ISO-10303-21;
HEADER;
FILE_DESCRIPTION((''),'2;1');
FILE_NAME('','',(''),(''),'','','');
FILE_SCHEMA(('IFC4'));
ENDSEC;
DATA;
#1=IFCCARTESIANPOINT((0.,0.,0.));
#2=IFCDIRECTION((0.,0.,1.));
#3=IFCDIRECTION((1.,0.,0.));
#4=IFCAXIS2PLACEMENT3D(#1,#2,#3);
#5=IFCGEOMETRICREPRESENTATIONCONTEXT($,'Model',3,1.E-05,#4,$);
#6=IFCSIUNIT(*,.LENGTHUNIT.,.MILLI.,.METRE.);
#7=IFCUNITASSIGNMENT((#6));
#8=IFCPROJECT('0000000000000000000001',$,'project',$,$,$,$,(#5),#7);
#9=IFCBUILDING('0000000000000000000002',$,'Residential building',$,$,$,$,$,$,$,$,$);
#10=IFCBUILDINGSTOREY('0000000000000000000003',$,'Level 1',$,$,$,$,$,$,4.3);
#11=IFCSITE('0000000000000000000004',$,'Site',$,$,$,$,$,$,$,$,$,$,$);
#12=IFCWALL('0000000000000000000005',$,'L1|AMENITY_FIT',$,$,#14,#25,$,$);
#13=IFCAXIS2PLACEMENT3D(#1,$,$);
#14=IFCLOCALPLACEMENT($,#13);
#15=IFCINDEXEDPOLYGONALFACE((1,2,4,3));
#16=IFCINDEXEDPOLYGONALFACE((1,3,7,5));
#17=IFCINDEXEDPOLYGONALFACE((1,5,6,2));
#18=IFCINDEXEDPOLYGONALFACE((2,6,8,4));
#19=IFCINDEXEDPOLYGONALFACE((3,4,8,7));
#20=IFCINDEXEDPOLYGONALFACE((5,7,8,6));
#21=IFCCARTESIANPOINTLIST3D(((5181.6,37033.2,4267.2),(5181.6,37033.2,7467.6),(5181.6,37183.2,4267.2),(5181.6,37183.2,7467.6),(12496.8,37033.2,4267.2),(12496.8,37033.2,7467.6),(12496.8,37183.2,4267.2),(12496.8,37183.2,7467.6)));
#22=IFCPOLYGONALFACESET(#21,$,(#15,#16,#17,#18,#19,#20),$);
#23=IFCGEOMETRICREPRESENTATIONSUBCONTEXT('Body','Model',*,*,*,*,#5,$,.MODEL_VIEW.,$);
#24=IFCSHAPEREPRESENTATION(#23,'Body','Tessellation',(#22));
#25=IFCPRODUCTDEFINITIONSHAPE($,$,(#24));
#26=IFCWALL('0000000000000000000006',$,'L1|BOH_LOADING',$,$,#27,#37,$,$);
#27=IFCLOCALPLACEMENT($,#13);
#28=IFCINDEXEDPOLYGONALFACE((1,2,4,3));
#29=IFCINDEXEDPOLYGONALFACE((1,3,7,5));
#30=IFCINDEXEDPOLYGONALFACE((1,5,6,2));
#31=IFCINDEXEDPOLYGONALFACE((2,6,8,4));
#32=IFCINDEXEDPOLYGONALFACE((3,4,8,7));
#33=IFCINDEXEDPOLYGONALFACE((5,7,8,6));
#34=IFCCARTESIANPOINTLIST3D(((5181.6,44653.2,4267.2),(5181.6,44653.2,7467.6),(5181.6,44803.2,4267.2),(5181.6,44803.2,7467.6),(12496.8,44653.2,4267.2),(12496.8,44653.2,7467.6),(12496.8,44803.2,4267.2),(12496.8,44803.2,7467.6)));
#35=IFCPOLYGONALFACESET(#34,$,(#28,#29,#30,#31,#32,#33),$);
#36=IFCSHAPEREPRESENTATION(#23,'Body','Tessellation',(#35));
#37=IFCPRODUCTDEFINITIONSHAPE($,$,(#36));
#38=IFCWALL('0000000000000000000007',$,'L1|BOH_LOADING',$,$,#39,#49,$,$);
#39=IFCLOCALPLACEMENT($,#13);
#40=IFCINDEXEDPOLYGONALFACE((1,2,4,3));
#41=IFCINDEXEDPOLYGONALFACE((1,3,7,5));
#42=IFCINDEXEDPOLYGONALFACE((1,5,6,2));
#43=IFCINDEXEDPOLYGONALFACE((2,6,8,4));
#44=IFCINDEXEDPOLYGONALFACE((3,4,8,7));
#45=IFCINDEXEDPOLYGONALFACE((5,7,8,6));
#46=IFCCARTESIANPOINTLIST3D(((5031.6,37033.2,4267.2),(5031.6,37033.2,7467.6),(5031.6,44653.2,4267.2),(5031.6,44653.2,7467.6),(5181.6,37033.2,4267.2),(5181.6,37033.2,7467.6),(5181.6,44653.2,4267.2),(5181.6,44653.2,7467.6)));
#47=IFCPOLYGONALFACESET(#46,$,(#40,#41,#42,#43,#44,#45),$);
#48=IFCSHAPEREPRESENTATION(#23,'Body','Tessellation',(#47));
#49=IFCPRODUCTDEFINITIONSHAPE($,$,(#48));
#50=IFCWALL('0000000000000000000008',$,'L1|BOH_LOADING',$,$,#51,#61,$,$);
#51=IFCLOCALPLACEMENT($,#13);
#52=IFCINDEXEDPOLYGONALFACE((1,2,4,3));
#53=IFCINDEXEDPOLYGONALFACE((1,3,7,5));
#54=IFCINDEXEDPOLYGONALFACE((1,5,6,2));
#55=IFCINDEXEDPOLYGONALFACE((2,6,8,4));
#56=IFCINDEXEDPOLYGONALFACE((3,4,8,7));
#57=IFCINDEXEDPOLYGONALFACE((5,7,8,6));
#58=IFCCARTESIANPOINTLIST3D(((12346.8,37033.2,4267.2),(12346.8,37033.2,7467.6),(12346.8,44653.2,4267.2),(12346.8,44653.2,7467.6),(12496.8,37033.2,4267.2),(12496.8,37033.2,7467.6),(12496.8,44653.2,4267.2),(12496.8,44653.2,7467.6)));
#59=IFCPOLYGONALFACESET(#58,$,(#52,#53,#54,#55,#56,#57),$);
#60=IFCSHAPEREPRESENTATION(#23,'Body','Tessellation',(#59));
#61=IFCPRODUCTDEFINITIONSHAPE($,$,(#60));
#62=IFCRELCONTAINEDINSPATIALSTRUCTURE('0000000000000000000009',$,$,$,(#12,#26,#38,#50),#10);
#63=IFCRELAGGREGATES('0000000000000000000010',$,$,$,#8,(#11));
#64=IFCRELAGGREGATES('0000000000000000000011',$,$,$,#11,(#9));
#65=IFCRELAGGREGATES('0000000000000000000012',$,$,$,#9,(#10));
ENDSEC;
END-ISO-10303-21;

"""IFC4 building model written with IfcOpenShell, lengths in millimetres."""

from ifc_helpers import new_model, si_unit, frame, origin_with_axes, place, context, subcontext, project, spatial, indexed_curve, outline, extrude, element, save


model = new_model("IFC4")

# Units and contexts
model_context = context("Model", 3, precision=1e-05, world=origin_with_axes())
body_context = subcontext(model_context, "Body", "Model", "MODEL_VIEW")
ifc_project = project(units=[si_unit("LENGTHUNIT", "METRE", prefix="MILLI")], contexts=[model_context])

# Site, building, storey
site = spatial("IfcSite", under=ifc_project, Name="Site")
building = spatial("IfcBuilding", under=site, Name="Residential building")
storey = spatial("IfcBuildingStorey", under=building, Name="Level 1", Elevation=4.3)

# Walls
for number, where, z_axis, x_axis, name in (
    (1, (5181.6, 37033.2, 4267.2), (0.0, 0.0, 1.0), (1.0, 0.0, 0.0), "L1|AMENITY_FIT"),
    (2, (5181.6, 44653.2, 4267.2), (0.0, 0.0, 1.0), (1.0, 0.0, 0.0), "L1|BOH_LOADING"),
):
    element("IfcWall", number, at=place(None, frame(where, z_axis=z_axis, x_axis=x_axis)), inside=storey, Name=name, context=body_context, shape_type="SweptSolid", body=[
        extrude(outline(indexed_curve([(0.0, 0.0), (0.0, 150.0), (7315.2, 150.0), (7315.2, 0.0), (0.0, 0.0)], self_intersect=False)), origin_with_axes(), (0.0, 0.0, 1.0), 3200.4),
    ])
for number, where, z_axis, x_axis, name in (
    (3, (5181.6, 37033.2, 4267.2), (0.0, 0.0, 1.0), (0.0, 1.0, 0.0), "L1|BOH_LOADING"),
    (4, (12496.8, 37033.2, 4267.2), (0.0, 0.0, 1.0), (0.0, 1.0, 0.0), "L1|BOH_LOADING"),
):
    element("IfcWall", number, at=place(None, frame(where, z_axis=z_axis, x_axis=x_axis)), inside=storey, Name=name, context=body_context, shape_type="SweptSolid", body=[
        extrude(outline(indexed_curve([(0.0, 0.0), (0.0, 150.0), (7620.0, 150.0), (7620.0, 0.0), (0.0, 0.0)], self_intersect=False)), origin_with_axes(), (0.0, 0.0, 1.0), 3200.4),
    ])

save(model, "model.ifc")
